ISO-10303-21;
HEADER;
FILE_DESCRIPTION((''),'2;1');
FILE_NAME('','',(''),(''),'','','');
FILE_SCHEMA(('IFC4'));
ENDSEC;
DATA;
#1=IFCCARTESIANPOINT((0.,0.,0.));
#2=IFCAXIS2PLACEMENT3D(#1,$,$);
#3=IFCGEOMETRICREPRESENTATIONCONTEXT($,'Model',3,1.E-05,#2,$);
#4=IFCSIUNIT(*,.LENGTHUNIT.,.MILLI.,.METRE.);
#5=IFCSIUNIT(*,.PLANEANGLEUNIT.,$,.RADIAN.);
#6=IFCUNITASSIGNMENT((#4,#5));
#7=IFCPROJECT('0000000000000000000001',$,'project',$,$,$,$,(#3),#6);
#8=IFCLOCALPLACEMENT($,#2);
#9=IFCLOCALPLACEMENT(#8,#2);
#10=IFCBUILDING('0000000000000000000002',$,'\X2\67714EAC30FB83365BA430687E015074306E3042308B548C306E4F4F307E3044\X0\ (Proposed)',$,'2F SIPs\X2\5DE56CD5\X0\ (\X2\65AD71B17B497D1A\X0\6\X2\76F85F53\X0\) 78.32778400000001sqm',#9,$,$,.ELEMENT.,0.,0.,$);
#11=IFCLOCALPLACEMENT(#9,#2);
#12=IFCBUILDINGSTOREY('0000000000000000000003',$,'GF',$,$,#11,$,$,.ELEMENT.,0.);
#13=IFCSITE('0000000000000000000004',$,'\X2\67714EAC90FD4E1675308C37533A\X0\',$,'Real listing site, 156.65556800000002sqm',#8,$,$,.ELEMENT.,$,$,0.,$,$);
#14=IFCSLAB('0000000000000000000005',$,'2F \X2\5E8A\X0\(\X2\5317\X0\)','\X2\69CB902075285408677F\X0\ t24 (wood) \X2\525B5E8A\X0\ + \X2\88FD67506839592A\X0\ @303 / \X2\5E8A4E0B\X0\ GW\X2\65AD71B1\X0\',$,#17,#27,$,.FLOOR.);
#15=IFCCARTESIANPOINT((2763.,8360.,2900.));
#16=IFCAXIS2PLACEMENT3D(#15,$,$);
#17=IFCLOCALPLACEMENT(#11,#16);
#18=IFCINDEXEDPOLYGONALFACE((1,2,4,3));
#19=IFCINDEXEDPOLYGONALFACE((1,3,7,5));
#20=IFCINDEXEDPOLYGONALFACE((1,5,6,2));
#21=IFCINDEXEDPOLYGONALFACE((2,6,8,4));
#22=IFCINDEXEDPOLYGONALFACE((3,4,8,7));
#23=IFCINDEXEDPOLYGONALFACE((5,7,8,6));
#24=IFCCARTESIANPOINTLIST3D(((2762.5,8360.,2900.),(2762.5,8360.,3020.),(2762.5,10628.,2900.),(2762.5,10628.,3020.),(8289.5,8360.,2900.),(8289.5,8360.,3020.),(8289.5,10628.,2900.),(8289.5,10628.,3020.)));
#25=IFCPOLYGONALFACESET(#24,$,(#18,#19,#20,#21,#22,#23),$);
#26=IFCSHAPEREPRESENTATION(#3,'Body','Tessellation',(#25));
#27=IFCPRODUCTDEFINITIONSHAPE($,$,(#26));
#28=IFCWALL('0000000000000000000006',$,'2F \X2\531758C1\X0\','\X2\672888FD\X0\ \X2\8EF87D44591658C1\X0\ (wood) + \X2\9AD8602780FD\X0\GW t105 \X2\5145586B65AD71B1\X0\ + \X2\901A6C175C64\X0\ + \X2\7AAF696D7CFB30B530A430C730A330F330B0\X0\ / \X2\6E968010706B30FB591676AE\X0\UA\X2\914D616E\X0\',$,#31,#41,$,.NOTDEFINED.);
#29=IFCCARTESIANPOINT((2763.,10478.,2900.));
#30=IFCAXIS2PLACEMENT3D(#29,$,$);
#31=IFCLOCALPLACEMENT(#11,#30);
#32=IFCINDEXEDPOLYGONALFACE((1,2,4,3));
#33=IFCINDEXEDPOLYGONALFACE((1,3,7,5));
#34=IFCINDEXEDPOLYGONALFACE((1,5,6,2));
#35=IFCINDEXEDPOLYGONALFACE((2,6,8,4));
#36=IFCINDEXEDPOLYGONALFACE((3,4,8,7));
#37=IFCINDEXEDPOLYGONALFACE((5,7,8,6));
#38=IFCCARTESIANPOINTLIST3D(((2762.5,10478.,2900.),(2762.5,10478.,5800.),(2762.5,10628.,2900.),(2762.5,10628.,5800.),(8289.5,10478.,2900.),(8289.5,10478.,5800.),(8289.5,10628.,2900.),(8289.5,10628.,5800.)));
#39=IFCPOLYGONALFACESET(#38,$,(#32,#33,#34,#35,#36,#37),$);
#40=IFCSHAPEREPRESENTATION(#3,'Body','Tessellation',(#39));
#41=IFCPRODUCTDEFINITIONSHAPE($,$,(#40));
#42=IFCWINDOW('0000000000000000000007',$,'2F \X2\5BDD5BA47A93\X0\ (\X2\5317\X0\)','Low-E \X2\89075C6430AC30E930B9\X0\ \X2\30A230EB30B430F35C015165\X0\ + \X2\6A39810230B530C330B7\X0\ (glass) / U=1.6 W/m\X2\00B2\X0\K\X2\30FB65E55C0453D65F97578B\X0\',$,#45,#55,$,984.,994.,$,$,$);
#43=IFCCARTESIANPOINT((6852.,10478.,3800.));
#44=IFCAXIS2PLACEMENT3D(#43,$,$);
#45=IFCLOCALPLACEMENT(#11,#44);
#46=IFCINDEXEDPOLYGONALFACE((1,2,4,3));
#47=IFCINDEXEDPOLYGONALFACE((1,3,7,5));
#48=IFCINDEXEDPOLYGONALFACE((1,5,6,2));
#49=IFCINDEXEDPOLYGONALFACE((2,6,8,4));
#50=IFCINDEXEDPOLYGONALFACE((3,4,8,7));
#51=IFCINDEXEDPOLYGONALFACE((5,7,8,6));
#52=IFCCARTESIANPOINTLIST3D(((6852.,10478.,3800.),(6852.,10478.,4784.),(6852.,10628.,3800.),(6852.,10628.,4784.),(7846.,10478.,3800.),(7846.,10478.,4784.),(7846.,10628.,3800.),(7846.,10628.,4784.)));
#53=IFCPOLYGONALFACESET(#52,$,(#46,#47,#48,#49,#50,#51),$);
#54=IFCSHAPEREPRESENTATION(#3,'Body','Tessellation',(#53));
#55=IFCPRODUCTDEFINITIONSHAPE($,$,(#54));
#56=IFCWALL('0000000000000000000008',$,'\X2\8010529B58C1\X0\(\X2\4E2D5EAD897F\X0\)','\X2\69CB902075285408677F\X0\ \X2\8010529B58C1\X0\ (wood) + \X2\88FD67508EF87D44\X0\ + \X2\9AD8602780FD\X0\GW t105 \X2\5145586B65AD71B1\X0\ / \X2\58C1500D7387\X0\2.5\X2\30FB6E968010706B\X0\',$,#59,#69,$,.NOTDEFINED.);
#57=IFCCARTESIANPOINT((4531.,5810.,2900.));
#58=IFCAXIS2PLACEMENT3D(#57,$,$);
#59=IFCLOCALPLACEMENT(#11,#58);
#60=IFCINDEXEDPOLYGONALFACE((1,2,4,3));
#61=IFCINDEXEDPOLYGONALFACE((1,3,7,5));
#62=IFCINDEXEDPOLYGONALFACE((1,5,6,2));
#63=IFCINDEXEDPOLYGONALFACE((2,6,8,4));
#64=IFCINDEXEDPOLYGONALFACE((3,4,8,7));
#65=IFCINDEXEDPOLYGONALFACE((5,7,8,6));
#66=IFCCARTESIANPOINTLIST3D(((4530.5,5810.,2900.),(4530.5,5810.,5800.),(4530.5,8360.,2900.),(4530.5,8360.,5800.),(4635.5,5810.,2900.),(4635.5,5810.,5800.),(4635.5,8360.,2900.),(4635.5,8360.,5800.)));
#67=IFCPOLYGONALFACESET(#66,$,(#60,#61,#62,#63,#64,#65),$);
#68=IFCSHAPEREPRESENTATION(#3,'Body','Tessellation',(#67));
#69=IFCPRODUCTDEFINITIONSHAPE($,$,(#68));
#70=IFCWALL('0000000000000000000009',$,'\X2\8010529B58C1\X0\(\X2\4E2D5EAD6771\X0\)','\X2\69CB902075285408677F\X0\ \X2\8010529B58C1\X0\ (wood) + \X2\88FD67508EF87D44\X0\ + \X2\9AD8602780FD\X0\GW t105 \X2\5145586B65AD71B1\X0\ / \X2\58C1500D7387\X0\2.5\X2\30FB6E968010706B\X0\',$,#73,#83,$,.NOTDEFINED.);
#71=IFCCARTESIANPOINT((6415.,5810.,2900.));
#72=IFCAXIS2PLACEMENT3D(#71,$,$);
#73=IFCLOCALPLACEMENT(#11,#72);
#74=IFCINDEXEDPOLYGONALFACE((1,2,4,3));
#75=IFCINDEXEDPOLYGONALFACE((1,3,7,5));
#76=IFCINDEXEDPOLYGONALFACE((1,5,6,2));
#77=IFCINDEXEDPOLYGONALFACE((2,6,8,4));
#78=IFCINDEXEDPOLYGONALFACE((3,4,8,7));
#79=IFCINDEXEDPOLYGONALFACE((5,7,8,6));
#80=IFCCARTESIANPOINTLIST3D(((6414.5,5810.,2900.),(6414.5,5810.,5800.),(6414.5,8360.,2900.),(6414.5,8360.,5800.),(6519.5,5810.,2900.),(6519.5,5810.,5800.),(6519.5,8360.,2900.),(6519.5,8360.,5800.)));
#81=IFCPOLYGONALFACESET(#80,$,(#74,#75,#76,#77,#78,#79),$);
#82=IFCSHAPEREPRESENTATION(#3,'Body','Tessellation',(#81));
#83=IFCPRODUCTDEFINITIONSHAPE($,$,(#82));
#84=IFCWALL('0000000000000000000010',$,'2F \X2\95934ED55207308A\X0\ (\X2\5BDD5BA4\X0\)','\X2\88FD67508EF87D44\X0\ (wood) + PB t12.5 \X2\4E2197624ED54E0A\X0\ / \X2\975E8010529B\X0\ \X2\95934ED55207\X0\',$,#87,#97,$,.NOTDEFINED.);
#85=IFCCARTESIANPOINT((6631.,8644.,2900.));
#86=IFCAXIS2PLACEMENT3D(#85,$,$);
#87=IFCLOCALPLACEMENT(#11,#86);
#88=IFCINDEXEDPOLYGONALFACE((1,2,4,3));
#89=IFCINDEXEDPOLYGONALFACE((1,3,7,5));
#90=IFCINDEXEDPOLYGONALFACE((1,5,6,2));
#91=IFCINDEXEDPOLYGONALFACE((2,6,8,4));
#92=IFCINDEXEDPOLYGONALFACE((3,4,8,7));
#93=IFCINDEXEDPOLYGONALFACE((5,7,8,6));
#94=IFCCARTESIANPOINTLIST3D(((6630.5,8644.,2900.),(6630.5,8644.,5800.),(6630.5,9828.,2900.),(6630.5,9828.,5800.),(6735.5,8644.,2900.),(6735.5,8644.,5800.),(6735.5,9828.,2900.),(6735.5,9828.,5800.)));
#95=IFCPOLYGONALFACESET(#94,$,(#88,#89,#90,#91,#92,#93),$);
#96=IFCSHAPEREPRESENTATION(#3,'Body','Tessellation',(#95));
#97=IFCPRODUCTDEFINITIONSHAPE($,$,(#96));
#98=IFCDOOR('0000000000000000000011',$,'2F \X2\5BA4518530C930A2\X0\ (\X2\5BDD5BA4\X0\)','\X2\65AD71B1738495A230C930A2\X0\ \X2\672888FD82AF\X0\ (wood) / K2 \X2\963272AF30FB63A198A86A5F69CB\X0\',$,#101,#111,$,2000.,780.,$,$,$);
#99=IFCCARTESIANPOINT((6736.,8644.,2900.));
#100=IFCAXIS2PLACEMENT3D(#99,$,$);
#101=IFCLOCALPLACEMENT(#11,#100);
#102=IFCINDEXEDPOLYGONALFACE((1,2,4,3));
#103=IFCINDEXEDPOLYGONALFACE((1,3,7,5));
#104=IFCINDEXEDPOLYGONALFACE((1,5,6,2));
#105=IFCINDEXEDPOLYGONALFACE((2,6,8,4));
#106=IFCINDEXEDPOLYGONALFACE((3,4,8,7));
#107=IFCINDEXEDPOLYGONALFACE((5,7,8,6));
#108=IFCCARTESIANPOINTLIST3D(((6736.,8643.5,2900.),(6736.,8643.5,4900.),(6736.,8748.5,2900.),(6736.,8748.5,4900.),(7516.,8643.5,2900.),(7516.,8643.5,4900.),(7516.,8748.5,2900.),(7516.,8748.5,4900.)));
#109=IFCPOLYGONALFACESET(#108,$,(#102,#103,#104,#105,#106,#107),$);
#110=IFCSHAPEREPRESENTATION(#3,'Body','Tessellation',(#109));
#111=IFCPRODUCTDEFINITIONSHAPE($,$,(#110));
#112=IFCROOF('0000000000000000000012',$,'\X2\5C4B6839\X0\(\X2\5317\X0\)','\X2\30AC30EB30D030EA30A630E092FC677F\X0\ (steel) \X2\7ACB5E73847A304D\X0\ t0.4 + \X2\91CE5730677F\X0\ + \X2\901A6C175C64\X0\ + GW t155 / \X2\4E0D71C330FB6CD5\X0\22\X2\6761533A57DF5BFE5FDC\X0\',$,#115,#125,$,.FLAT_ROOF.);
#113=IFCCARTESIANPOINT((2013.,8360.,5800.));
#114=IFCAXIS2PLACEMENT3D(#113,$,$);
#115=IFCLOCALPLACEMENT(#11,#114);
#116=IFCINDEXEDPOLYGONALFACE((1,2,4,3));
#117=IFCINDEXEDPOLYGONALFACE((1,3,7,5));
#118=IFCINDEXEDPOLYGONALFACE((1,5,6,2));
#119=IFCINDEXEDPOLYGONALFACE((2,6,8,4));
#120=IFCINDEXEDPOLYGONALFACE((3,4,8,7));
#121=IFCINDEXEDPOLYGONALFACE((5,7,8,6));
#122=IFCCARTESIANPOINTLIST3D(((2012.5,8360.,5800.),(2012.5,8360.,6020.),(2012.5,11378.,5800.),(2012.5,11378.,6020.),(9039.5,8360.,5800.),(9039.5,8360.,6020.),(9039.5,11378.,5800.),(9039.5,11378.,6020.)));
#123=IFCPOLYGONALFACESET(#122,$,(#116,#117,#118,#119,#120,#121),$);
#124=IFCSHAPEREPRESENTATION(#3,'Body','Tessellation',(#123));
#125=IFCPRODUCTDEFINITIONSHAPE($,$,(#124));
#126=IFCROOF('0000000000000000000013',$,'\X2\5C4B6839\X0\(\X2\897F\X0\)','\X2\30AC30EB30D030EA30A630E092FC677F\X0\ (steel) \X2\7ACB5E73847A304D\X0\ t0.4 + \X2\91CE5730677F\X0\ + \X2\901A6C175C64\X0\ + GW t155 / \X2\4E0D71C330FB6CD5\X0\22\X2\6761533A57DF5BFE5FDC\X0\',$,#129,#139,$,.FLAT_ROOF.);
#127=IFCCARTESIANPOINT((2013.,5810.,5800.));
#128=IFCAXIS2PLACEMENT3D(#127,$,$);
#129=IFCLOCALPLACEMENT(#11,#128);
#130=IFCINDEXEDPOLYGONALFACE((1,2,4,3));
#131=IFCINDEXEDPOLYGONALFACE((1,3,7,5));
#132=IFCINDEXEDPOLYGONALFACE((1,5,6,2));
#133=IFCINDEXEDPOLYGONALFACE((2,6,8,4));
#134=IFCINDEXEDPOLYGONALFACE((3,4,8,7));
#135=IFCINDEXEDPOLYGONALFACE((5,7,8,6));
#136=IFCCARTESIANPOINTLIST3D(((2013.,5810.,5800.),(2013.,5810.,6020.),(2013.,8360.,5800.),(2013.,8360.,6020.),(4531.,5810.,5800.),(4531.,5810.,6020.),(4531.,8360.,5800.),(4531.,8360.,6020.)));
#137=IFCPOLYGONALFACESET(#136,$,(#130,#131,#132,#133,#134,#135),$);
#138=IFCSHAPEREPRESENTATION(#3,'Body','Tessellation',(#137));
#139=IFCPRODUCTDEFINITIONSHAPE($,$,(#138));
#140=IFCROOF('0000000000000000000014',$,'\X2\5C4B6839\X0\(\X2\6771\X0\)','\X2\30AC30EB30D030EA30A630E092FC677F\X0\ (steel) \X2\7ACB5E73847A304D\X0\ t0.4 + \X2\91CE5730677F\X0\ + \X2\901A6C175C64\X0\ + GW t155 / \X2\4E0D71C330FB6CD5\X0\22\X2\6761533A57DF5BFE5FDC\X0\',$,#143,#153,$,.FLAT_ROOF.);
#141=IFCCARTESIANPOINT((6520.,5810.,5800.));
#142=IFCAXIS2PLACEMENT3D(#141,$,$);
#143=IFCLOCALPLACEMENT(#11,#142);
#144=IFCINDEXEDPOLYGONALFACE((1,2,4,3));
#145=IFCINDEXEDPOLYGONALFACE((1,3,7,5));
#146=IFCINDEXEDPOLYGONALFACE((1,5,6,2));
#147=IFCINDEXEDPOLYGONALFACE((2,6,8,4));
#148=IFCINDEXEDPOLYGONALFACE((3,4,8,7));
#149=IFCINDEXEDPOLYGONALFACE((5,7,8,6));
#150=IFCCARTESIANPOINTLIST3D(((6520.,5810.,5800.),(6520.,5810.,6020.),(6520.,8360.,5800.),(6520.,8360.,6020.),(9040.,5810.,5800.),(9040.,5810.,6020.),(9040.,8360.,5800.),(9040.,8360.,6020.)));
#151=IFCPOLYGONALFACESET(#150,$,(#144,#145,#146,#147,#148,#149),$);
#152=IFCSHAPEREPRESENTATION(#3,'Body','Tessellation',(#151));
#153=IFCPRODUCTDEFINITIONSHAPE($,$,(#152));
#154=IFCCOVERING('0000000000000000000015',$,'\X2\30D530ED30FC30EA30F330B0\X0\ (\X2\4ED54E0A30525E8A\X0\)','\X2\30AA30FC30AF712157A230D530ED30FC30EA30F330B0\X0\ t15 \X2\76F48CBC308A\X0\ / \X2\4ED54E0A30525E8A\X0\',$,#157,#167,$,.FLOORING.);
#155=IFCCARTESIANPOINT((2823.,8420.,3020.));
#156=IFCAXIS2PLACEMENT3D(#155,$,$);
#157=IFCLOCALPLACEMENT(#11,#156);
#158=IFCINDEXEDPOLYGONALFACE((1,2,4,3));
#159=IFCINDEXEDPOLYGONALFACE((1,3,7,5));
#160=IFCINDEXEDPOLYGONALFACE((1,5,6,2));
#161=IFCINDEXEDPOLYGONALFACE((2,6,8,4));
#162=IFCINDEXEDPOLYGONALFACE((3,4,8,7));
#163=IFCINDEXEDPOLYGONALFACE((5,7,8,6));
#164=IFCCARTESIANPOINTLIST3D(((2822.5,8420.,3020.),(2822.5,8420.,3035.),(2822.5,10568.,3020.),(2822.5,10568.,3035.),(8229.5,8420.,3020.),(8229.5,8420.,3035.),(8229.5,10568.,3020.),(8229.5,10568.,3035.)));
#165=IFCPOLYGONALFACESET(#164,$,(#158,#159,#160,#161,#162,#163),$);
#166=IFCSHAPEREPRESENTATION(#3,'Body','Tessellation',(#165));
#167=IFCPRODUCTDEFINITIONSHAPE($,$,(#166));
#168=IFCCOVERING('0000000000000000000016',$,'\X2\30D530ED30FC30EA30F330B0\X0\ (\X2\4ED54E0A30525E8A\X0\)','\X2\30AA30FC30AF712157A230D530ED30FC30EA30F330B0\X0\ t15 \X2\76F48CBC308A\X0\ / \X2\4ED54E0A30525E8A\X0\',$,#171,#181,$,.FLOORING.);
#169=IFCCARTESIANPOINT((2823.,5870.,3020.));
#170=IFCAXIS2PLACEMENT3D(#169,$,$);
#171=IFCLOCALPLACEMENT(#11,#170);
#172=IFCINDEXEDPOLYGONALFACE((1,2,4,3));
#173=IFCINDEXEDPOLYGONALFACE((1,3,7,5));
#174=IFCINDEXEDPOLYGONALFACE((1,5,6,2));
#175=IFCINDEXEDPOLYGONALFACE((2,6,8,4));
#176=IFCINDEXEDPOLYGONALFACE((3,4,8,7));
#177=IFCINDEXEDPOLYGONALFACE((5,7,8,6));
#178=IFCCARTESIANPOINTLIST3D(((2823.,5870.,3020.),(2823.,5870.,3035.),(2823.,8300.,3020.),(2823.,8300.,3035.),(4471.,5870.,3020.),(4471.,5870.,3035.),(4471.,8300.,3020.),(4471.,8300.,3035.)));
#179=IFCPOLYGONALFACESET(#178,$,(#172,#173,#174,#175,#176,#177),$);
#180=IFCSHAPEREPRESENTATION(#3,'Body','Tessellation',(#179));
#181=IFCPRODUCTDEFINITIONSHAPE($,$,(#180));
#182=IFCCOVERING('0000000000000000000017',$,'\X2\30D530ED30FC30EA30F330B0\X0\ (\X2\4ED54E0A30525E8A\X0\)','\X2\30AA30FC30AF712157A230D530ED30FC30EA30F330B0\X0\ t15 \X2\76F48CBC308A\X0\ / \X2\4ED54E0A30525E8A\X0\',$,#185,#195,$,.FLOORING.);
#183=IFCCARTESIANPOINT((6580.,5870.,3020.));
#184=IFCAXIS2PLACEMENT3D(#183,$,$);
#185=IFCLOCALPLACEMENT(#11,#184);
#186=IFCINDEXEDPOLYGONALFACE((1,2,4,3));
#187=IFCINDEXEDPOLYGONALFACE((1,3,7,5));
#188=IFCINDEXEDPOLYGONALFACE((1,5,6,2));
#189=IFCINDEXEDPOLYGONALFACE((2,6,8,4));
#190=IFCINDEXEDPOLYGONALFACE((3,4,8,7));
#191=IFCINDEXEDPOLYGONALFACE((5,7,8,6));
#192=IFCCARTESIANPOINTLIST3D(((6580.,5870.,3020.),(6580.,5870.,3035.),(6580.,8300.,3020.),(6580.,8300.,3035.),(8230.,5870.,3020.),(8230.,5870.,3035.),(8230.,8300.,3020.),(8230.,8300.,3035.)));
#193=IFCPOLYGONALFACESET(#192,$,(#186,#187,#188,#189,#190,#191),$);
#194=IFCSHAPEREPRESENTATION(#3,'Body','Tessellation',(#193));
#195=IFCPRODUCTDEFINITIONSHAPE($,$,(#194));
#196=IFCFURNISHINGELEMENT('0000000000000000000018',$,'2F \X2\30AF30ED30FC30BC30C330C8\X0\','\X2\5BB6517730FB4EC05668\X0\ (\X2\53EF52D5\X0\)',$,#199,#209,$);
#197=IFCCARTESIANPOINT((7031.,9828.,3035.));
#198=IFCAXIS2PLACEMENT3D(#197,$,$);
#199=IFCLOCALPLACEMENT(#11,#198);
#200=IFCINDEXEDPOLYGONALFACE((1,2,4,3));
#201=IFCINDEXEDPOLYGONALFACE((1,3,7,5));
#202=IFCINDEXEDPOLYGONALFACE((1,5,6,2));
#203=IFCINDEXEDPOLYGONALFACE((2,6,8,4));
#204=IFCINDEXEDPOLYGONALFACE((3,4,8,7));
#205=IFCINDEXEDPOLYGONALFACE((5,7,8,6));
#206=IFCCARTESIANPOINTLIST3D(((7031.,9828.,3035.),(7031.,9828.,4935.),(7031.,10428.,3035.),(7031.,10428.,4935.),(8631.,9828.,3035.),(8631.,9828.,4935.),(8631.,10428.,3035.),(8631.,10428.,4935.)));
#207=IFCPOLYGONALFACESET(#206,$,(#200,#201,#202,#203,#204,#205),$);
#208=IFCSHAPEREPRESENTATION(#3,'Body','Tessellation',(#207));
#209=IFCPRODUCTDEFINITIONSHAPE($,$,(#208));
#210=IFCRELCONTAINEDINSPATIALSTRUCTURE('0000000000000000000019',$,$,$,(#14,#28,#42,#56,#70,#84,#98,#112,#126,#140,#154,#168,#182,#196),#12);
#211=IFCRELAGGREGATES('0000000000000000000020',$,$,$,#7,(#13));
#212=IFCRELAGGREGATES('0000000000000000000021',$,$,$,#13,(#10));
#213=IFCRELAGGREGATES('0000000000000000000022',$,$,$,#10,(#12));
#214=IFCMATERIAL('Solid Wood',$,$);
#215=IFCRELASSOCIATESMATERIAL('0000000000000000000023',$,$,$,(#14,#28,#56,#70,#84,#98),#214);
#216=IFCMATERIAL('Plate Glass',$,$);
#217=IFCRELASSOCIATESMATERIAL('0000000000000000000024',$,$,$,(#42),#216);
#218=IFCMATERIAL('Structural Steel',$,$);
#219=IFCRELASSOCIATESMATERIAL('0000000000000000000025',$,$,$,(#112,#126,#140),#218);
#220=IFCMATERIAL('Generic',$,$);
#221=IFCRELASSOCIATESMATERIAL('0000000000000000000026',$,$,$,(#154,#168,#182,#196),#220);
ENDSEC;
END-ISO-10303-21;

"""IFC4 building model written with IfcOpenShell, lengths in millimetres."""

from ifc_helpers import new_model, si_unit, frame, frame_2d, origin, place, context, project, spatial, rectangle, extrude, material, element, fill, save


model = new_model("IFC4")

# Units and contexts
model_context = context("Model", 3, precision=1e-05, world=origin())
ifc_project = project(units=[si_unit("LENGTHUNIT", "METRE", prefix="MILLI"), si_unit("PLANEANGLEUNIT", "RADIAN")], contexts=[model_context])

# Site, building, storey
site_placement = place(None, origin())
site = spatial("IfcSite", under=ifc_project, at=site_placement, Name="東京都世田谷区", ObjectType="Real listing site, 156.65556800000002sqm", CompositionType="ELEMENT", RefElevation=0.0)
building_placement = place(site_placement, origin())
building = spatial("IfcBuilding", under=site, at=building_placement, Name="東京・茶室と縁側のある和の住まい (Proposed)", ObjectType="2F SIPs工法 (断熱等級6相当) 78.32778400000001sqm", CompositionType="ELEMENT", ElevationOfRefHeight=0.0, ElevationOfTerrain=0.0)
storey_placement = place(building_placement, origin())
storey = spatial("IfcBuildingStorey", under=building, at=storey_placement, Name="GF", CompositionType="ELEMENT", Elevation=0.0)

# Slab
ifc_material_1 = material(Name="Solid Wood")
slab_placement = place(storey_placement, frame((2763.0, 8360.0, 2900.0)))
element("IfcSlab", 1, at=slab_placement, inside=storey, material=ifc_material_1, Name="2F 床(北)", Description="構造用合板 t24 (wood) 剛床 + 製材根太 @303 / 床下 GW断熱", PredefinedType="FLOOR", context=model_context, shape_type="SweptSolid", body=[
    extrude(rectangle(XDim=5527.0, YDim=2268.0, at=frame_2d((2763.0, 1134.0))), frame((2763.0, 8360.0, 2900.0)), (0.0, 0.0, 1.0), 120.0),
])

# Wall, opening, window
wall_1_placement = place(storey_placement, frame((2763.0, 10478.0, 2900.0)))
wall_1 = element("IfcWall", 2, at=wall_1_placement, inside=storey, material=ifc_material_1, Name="2F 北壁", Description="木製 軸組外壁 (wood) + 高性能GW t105 充填断熱 + 通気層 + 窯業系サイディング / 準耐火・外皮UA配慮", PredefinedType="NOTDEFINED", context=model_context, shape_type="SweptSolid", body=[
    extrude(rectangle(XDim=5527.0, YDim=150.0, at=frame_2d((2763.0, 75.0))), frame((2763.0, 10478.0, 2900.0)), (0.0, 0.0, 1.0), 2900.0),
])
opening_1_placement = place(storey_placement, frame((6852.0, 10478.0, 3800.0)))
opening_1 = element("IfcOpeningElement", 3, at=opening_1_placement, cuts=wall_1, PredefinedType="NOTDEFINED", context=model_context, shape_type="SweptSolid", body=[
    extrude(rectangle(XDim=994.0, YDim=150.0, at=frame_2d((497.0, 75.0))), frame((6852.0, 10478.0, 3800.0)), (0.0, 0.0, 1.0), 984.0),
])
ifc_material_2 = material(Name="Plate Glass")
window_1_placement = place(storey_placement, frame((6852.0, 10478.0, 3800.0)))
window_1 = element("IfcWindow", 4, at=window_1_placement, inside=storey, material=ifc_material_2, Name="2F 寝室窓 (北)", Description="Low-E 複層ガラス アルゴン封入 + 樹脂サッシ (glass) / U=1.6 W/m²K・日射取得型", OverallHeight=984.0, OverallWidth=994.0, context=model_context, shape_type="SweptSolid", body=[
    extrude(rectangle(XDim=994.0, YDim=150.0, at=frame_2d((497.0, 75.0))), frame((6852.0, 10478.0, 3800.0)), (0.0, 0.0, 1.0), 984.0),
])
fill(opening_1, window_1)

# Walls
wall_2_placement = place(storey_placement, frame((4531.0, 5810.0, 2900.0)))
element("IfcWall", 5, at=wall_2_placement, inside=storey, material=ifc_material_1, Name="耐力壁(中庭西)", Description="構造用合板 耐力壁 (wood) + 製材軸組 + 高性能GW t105 充填断熱 / 壁倍率2.5・準耐火", PredefinedType="NOTDEFINED", context=model_context, shape_type="SweptSolid", body=[
    extrude(rectangle(XDim=105.0, YDim=2550.0, at=frame_2d((52.0, 1275.0))), frame((4531.0, 5810.0, 2900.0)), (0.0, 0.0, 1.0), 2900.0),
])
wall_3_placement = place(storey_placement, frame((6415.0, 5810.0, 2900.0)))
element("IfcWall", 6, at=wall_3_placement, inside=storey, material=ifc_material_1, Name="耐力壁(中庭東)", Description="構造用合板 耐力壁 (wood) + 製材軸組 + 高性能GW t105 充填断熱 / 壁倍率2.5・準耐火", PredefinedType="NOTDEFINED", context=model_context, shape_type="SweptSolid", body=[
    extrude(rectangle(XDim=105.0, YDim=2550.0, at=frame_2d((52.0, 1275.0))), frame((6415.0, 5810.0, 2900.0)), (0.0, 0.0, 1.0), 2900.0),
])
wall_4_placement = place(storey_placement, frame((6631.0, 8644.0, 2900.0)))
element("IfcWall", 7, at=wall_4_placement, inside=storey, material=ifc_material_1, Name="2F 間仕切り (寝室)", Description="製材軸組 (wood) + PB t12.5 両面仕上 / 非耐力 間仕切", PredefinedType="NOTDEFINED", context=model_context, shape_type="SweptSolid", body=[
    extrude(rectangle(XDim=105.0, YDim=1184.0, at=frame_2d((52.0, 592.0))), frame((6631.0, 8644.0, 2900.0)), (0.0, 0.0, 1.0), 2900.0),
])

# Door
door_placement = place(storey_placement, frame((6736.0, 8644.0, 2900.0)))
element("IfcDoor", 8, at=door_placement, inside=storey, material=ifc_material_1, Name="2F 室内ドア (寝室)", Description="断熱玄関ドア 木製芯 (wood) / K2 防犯・採風機構", OverallHeight=2000.0, OverallWidth=780.0, context=model_context, shape_type="SweptSolid", body=[
    extrude(rectangle(XDim=780.0, YDim=105.0, at=frame_2d((390.0, 52.0))), frame((6736.0, 8644.0, 2900.0)), (0.0, 0.0, 1.0), 2000.0),
])

# Roofs
ifc_material_3 = material(Name="Structural Steel")
for number, where, name in (
    (9, (2013.0, 8360.0, 5800.0), "屋根(北)"),
):
    element("IfcRoof", number, at=place(storey_placement, frame(where)), inside=storey, material=ifc_material_3, Name=name, Description="ガルバリウム鋼板 (steel) 立平葺き t0.4 + 野地板 + 通気層 + GW t155 / 不燃・法22条区域対応", PredefinedType="FLAT_ROOF", context=model_context, shape_type="SweptSolid", body=[
        extrude(rectangle(XDim=7027.0, YDim=3018.0, at=frame_2d((3513.0, 1509.0))), frame((2013.0, 8360.0, 5800.0)), (0.0, 0.0, 1.0), 220.0),
    ])
roof_1_placement = place(storey_placement, frame((2013.0, 5810.0, 5800.0)))
element("IfcRoof", 10, at=roof_1_placement, inside=storey, material=ifc_material_3, Name="屋根(西)", Description="ガルバリウム鋼板 (steel) 立平葺き t0.4 + 野地板 + 通気層 + GW t155 / 不燃・法22条区域対応", PredefinedType="FLAT_ROOF", context=model_context, shape_type="SweptSolid", body=[
    extrude(rectangle(XDim=2518.0, YDim=2550.0, at=frame_2d((1259.0, 1275.0))), frame((2013.0, 5810.0, 5800.0)), (0.0, 0.0, 1.0), 220.0),
])
roof_2_placement = place(storey_placement, frame((6520.0, 5810.0, 5800.0)))
element("IfcRoof", 11, at=roof_2_placement, inside=storey, material=ifc_material_3, Name="屋根(東)", Description="ガルバリウム鋼板 (steel) 立平葺き t0.4 + 野地板 + 通気層 + GW t155 / 不燃・法22条区域対応", PredefinedType="FLAT_ROOF", context=model_context, shape_type="SweptSolid", body=[
    extrude(rectangle(XDim=2520.0, YDim=2550.0, at=frame_2d((1260.0, 1275.0))), frame((6520.0, 5810.0, 5800.0)), (0.0, 0.0, 1.0), 220.0),
])

# Coverings
ifc_material_4 = material(Name="Generic")
covering_1_placement = place(storey_placement, frame((2823.0, 8420.0, 3020.0)))
element("IfcCovering", 12, at=covering_1_placement, inside=storey, material=ifc_material_4, Name="フローリング (仕上げ床)", Description="オーク無垢フローリング t15 直貼り / 仕上げ床", PredefinedType="FLOORING", context=model_context, shape_type="SweptSolid", body=[
    extrude(rectangle(XDim=5407.0, YDim=2148.0, at=frame_2d((2703.0, 1074.0))), frame((2823.0, 8420.0, 3020.0)), (0.0, 0.0, 1.0), 15.0),
])
covering_2_placement = place(storey_placement, frame((2823.0, 5870.0, 3020.0)))
element("IfcCovering", 13, at=covering_2_placement, inside=storey, material=ifc_material_4, Name="フローリング (仕上げ床)", Description="オーク無垢フローリング t15 直貼り / 仕上げ床", PredefinedType="FLOORING", context=model_context, shape_type="SweptSolid", body=[
    extrude(rectangle(XDim=1648.0, YDim=2430.0, at=frame_2d((824.0, 1215.0))), frame((2823.0, 5870.0, 3020.0)), (0.0, 0.0, 1.0), 15.0),
])
covering_3_placement = place(storey_placement, frame((6580.0, 5870.0, 3020.0)))
element("IfcCovering", 14, at=covering_3_placement, inside=storey, material=ifc_material_4, Name="フローリング (仕上げ床)", Description="オーク無垢フローリング t15 直貼り / 仕上げ床", PredefinedType="FLOORING", context=model_context, shape_type="SweptSolid", body=[
    extrude(rectangle(XDim=1650.0, YDim=2430.0, at=frame_2d((825.0, 1215.0))), frame((6580.0, 5870.0, 3020.0)), (0.0, 0.0, 1.0), 15.0),
])

# Furnishing element
furnishing_1_placement = place(storey_placement, frame((7031.0, 9828.0, 3035.0)))
element("IfcFurnishingElement", 15, at=furnishing_1_placement, inside=storey, material=ifc_material_4, Name="2F クローゼット", Description="家具・什器 (可動)", context=model_context, shape_type="SweptSolid", body=[
    extrude(rectangle(XDim=1600.0, YDim=600.0, at=frame_2d((800.0, 300.0))), frame((7031.0, 9828.0, 3035.0)), (0.0, 0.0, 1.0), 1900.0),
])

save(model, "model.ifc")
